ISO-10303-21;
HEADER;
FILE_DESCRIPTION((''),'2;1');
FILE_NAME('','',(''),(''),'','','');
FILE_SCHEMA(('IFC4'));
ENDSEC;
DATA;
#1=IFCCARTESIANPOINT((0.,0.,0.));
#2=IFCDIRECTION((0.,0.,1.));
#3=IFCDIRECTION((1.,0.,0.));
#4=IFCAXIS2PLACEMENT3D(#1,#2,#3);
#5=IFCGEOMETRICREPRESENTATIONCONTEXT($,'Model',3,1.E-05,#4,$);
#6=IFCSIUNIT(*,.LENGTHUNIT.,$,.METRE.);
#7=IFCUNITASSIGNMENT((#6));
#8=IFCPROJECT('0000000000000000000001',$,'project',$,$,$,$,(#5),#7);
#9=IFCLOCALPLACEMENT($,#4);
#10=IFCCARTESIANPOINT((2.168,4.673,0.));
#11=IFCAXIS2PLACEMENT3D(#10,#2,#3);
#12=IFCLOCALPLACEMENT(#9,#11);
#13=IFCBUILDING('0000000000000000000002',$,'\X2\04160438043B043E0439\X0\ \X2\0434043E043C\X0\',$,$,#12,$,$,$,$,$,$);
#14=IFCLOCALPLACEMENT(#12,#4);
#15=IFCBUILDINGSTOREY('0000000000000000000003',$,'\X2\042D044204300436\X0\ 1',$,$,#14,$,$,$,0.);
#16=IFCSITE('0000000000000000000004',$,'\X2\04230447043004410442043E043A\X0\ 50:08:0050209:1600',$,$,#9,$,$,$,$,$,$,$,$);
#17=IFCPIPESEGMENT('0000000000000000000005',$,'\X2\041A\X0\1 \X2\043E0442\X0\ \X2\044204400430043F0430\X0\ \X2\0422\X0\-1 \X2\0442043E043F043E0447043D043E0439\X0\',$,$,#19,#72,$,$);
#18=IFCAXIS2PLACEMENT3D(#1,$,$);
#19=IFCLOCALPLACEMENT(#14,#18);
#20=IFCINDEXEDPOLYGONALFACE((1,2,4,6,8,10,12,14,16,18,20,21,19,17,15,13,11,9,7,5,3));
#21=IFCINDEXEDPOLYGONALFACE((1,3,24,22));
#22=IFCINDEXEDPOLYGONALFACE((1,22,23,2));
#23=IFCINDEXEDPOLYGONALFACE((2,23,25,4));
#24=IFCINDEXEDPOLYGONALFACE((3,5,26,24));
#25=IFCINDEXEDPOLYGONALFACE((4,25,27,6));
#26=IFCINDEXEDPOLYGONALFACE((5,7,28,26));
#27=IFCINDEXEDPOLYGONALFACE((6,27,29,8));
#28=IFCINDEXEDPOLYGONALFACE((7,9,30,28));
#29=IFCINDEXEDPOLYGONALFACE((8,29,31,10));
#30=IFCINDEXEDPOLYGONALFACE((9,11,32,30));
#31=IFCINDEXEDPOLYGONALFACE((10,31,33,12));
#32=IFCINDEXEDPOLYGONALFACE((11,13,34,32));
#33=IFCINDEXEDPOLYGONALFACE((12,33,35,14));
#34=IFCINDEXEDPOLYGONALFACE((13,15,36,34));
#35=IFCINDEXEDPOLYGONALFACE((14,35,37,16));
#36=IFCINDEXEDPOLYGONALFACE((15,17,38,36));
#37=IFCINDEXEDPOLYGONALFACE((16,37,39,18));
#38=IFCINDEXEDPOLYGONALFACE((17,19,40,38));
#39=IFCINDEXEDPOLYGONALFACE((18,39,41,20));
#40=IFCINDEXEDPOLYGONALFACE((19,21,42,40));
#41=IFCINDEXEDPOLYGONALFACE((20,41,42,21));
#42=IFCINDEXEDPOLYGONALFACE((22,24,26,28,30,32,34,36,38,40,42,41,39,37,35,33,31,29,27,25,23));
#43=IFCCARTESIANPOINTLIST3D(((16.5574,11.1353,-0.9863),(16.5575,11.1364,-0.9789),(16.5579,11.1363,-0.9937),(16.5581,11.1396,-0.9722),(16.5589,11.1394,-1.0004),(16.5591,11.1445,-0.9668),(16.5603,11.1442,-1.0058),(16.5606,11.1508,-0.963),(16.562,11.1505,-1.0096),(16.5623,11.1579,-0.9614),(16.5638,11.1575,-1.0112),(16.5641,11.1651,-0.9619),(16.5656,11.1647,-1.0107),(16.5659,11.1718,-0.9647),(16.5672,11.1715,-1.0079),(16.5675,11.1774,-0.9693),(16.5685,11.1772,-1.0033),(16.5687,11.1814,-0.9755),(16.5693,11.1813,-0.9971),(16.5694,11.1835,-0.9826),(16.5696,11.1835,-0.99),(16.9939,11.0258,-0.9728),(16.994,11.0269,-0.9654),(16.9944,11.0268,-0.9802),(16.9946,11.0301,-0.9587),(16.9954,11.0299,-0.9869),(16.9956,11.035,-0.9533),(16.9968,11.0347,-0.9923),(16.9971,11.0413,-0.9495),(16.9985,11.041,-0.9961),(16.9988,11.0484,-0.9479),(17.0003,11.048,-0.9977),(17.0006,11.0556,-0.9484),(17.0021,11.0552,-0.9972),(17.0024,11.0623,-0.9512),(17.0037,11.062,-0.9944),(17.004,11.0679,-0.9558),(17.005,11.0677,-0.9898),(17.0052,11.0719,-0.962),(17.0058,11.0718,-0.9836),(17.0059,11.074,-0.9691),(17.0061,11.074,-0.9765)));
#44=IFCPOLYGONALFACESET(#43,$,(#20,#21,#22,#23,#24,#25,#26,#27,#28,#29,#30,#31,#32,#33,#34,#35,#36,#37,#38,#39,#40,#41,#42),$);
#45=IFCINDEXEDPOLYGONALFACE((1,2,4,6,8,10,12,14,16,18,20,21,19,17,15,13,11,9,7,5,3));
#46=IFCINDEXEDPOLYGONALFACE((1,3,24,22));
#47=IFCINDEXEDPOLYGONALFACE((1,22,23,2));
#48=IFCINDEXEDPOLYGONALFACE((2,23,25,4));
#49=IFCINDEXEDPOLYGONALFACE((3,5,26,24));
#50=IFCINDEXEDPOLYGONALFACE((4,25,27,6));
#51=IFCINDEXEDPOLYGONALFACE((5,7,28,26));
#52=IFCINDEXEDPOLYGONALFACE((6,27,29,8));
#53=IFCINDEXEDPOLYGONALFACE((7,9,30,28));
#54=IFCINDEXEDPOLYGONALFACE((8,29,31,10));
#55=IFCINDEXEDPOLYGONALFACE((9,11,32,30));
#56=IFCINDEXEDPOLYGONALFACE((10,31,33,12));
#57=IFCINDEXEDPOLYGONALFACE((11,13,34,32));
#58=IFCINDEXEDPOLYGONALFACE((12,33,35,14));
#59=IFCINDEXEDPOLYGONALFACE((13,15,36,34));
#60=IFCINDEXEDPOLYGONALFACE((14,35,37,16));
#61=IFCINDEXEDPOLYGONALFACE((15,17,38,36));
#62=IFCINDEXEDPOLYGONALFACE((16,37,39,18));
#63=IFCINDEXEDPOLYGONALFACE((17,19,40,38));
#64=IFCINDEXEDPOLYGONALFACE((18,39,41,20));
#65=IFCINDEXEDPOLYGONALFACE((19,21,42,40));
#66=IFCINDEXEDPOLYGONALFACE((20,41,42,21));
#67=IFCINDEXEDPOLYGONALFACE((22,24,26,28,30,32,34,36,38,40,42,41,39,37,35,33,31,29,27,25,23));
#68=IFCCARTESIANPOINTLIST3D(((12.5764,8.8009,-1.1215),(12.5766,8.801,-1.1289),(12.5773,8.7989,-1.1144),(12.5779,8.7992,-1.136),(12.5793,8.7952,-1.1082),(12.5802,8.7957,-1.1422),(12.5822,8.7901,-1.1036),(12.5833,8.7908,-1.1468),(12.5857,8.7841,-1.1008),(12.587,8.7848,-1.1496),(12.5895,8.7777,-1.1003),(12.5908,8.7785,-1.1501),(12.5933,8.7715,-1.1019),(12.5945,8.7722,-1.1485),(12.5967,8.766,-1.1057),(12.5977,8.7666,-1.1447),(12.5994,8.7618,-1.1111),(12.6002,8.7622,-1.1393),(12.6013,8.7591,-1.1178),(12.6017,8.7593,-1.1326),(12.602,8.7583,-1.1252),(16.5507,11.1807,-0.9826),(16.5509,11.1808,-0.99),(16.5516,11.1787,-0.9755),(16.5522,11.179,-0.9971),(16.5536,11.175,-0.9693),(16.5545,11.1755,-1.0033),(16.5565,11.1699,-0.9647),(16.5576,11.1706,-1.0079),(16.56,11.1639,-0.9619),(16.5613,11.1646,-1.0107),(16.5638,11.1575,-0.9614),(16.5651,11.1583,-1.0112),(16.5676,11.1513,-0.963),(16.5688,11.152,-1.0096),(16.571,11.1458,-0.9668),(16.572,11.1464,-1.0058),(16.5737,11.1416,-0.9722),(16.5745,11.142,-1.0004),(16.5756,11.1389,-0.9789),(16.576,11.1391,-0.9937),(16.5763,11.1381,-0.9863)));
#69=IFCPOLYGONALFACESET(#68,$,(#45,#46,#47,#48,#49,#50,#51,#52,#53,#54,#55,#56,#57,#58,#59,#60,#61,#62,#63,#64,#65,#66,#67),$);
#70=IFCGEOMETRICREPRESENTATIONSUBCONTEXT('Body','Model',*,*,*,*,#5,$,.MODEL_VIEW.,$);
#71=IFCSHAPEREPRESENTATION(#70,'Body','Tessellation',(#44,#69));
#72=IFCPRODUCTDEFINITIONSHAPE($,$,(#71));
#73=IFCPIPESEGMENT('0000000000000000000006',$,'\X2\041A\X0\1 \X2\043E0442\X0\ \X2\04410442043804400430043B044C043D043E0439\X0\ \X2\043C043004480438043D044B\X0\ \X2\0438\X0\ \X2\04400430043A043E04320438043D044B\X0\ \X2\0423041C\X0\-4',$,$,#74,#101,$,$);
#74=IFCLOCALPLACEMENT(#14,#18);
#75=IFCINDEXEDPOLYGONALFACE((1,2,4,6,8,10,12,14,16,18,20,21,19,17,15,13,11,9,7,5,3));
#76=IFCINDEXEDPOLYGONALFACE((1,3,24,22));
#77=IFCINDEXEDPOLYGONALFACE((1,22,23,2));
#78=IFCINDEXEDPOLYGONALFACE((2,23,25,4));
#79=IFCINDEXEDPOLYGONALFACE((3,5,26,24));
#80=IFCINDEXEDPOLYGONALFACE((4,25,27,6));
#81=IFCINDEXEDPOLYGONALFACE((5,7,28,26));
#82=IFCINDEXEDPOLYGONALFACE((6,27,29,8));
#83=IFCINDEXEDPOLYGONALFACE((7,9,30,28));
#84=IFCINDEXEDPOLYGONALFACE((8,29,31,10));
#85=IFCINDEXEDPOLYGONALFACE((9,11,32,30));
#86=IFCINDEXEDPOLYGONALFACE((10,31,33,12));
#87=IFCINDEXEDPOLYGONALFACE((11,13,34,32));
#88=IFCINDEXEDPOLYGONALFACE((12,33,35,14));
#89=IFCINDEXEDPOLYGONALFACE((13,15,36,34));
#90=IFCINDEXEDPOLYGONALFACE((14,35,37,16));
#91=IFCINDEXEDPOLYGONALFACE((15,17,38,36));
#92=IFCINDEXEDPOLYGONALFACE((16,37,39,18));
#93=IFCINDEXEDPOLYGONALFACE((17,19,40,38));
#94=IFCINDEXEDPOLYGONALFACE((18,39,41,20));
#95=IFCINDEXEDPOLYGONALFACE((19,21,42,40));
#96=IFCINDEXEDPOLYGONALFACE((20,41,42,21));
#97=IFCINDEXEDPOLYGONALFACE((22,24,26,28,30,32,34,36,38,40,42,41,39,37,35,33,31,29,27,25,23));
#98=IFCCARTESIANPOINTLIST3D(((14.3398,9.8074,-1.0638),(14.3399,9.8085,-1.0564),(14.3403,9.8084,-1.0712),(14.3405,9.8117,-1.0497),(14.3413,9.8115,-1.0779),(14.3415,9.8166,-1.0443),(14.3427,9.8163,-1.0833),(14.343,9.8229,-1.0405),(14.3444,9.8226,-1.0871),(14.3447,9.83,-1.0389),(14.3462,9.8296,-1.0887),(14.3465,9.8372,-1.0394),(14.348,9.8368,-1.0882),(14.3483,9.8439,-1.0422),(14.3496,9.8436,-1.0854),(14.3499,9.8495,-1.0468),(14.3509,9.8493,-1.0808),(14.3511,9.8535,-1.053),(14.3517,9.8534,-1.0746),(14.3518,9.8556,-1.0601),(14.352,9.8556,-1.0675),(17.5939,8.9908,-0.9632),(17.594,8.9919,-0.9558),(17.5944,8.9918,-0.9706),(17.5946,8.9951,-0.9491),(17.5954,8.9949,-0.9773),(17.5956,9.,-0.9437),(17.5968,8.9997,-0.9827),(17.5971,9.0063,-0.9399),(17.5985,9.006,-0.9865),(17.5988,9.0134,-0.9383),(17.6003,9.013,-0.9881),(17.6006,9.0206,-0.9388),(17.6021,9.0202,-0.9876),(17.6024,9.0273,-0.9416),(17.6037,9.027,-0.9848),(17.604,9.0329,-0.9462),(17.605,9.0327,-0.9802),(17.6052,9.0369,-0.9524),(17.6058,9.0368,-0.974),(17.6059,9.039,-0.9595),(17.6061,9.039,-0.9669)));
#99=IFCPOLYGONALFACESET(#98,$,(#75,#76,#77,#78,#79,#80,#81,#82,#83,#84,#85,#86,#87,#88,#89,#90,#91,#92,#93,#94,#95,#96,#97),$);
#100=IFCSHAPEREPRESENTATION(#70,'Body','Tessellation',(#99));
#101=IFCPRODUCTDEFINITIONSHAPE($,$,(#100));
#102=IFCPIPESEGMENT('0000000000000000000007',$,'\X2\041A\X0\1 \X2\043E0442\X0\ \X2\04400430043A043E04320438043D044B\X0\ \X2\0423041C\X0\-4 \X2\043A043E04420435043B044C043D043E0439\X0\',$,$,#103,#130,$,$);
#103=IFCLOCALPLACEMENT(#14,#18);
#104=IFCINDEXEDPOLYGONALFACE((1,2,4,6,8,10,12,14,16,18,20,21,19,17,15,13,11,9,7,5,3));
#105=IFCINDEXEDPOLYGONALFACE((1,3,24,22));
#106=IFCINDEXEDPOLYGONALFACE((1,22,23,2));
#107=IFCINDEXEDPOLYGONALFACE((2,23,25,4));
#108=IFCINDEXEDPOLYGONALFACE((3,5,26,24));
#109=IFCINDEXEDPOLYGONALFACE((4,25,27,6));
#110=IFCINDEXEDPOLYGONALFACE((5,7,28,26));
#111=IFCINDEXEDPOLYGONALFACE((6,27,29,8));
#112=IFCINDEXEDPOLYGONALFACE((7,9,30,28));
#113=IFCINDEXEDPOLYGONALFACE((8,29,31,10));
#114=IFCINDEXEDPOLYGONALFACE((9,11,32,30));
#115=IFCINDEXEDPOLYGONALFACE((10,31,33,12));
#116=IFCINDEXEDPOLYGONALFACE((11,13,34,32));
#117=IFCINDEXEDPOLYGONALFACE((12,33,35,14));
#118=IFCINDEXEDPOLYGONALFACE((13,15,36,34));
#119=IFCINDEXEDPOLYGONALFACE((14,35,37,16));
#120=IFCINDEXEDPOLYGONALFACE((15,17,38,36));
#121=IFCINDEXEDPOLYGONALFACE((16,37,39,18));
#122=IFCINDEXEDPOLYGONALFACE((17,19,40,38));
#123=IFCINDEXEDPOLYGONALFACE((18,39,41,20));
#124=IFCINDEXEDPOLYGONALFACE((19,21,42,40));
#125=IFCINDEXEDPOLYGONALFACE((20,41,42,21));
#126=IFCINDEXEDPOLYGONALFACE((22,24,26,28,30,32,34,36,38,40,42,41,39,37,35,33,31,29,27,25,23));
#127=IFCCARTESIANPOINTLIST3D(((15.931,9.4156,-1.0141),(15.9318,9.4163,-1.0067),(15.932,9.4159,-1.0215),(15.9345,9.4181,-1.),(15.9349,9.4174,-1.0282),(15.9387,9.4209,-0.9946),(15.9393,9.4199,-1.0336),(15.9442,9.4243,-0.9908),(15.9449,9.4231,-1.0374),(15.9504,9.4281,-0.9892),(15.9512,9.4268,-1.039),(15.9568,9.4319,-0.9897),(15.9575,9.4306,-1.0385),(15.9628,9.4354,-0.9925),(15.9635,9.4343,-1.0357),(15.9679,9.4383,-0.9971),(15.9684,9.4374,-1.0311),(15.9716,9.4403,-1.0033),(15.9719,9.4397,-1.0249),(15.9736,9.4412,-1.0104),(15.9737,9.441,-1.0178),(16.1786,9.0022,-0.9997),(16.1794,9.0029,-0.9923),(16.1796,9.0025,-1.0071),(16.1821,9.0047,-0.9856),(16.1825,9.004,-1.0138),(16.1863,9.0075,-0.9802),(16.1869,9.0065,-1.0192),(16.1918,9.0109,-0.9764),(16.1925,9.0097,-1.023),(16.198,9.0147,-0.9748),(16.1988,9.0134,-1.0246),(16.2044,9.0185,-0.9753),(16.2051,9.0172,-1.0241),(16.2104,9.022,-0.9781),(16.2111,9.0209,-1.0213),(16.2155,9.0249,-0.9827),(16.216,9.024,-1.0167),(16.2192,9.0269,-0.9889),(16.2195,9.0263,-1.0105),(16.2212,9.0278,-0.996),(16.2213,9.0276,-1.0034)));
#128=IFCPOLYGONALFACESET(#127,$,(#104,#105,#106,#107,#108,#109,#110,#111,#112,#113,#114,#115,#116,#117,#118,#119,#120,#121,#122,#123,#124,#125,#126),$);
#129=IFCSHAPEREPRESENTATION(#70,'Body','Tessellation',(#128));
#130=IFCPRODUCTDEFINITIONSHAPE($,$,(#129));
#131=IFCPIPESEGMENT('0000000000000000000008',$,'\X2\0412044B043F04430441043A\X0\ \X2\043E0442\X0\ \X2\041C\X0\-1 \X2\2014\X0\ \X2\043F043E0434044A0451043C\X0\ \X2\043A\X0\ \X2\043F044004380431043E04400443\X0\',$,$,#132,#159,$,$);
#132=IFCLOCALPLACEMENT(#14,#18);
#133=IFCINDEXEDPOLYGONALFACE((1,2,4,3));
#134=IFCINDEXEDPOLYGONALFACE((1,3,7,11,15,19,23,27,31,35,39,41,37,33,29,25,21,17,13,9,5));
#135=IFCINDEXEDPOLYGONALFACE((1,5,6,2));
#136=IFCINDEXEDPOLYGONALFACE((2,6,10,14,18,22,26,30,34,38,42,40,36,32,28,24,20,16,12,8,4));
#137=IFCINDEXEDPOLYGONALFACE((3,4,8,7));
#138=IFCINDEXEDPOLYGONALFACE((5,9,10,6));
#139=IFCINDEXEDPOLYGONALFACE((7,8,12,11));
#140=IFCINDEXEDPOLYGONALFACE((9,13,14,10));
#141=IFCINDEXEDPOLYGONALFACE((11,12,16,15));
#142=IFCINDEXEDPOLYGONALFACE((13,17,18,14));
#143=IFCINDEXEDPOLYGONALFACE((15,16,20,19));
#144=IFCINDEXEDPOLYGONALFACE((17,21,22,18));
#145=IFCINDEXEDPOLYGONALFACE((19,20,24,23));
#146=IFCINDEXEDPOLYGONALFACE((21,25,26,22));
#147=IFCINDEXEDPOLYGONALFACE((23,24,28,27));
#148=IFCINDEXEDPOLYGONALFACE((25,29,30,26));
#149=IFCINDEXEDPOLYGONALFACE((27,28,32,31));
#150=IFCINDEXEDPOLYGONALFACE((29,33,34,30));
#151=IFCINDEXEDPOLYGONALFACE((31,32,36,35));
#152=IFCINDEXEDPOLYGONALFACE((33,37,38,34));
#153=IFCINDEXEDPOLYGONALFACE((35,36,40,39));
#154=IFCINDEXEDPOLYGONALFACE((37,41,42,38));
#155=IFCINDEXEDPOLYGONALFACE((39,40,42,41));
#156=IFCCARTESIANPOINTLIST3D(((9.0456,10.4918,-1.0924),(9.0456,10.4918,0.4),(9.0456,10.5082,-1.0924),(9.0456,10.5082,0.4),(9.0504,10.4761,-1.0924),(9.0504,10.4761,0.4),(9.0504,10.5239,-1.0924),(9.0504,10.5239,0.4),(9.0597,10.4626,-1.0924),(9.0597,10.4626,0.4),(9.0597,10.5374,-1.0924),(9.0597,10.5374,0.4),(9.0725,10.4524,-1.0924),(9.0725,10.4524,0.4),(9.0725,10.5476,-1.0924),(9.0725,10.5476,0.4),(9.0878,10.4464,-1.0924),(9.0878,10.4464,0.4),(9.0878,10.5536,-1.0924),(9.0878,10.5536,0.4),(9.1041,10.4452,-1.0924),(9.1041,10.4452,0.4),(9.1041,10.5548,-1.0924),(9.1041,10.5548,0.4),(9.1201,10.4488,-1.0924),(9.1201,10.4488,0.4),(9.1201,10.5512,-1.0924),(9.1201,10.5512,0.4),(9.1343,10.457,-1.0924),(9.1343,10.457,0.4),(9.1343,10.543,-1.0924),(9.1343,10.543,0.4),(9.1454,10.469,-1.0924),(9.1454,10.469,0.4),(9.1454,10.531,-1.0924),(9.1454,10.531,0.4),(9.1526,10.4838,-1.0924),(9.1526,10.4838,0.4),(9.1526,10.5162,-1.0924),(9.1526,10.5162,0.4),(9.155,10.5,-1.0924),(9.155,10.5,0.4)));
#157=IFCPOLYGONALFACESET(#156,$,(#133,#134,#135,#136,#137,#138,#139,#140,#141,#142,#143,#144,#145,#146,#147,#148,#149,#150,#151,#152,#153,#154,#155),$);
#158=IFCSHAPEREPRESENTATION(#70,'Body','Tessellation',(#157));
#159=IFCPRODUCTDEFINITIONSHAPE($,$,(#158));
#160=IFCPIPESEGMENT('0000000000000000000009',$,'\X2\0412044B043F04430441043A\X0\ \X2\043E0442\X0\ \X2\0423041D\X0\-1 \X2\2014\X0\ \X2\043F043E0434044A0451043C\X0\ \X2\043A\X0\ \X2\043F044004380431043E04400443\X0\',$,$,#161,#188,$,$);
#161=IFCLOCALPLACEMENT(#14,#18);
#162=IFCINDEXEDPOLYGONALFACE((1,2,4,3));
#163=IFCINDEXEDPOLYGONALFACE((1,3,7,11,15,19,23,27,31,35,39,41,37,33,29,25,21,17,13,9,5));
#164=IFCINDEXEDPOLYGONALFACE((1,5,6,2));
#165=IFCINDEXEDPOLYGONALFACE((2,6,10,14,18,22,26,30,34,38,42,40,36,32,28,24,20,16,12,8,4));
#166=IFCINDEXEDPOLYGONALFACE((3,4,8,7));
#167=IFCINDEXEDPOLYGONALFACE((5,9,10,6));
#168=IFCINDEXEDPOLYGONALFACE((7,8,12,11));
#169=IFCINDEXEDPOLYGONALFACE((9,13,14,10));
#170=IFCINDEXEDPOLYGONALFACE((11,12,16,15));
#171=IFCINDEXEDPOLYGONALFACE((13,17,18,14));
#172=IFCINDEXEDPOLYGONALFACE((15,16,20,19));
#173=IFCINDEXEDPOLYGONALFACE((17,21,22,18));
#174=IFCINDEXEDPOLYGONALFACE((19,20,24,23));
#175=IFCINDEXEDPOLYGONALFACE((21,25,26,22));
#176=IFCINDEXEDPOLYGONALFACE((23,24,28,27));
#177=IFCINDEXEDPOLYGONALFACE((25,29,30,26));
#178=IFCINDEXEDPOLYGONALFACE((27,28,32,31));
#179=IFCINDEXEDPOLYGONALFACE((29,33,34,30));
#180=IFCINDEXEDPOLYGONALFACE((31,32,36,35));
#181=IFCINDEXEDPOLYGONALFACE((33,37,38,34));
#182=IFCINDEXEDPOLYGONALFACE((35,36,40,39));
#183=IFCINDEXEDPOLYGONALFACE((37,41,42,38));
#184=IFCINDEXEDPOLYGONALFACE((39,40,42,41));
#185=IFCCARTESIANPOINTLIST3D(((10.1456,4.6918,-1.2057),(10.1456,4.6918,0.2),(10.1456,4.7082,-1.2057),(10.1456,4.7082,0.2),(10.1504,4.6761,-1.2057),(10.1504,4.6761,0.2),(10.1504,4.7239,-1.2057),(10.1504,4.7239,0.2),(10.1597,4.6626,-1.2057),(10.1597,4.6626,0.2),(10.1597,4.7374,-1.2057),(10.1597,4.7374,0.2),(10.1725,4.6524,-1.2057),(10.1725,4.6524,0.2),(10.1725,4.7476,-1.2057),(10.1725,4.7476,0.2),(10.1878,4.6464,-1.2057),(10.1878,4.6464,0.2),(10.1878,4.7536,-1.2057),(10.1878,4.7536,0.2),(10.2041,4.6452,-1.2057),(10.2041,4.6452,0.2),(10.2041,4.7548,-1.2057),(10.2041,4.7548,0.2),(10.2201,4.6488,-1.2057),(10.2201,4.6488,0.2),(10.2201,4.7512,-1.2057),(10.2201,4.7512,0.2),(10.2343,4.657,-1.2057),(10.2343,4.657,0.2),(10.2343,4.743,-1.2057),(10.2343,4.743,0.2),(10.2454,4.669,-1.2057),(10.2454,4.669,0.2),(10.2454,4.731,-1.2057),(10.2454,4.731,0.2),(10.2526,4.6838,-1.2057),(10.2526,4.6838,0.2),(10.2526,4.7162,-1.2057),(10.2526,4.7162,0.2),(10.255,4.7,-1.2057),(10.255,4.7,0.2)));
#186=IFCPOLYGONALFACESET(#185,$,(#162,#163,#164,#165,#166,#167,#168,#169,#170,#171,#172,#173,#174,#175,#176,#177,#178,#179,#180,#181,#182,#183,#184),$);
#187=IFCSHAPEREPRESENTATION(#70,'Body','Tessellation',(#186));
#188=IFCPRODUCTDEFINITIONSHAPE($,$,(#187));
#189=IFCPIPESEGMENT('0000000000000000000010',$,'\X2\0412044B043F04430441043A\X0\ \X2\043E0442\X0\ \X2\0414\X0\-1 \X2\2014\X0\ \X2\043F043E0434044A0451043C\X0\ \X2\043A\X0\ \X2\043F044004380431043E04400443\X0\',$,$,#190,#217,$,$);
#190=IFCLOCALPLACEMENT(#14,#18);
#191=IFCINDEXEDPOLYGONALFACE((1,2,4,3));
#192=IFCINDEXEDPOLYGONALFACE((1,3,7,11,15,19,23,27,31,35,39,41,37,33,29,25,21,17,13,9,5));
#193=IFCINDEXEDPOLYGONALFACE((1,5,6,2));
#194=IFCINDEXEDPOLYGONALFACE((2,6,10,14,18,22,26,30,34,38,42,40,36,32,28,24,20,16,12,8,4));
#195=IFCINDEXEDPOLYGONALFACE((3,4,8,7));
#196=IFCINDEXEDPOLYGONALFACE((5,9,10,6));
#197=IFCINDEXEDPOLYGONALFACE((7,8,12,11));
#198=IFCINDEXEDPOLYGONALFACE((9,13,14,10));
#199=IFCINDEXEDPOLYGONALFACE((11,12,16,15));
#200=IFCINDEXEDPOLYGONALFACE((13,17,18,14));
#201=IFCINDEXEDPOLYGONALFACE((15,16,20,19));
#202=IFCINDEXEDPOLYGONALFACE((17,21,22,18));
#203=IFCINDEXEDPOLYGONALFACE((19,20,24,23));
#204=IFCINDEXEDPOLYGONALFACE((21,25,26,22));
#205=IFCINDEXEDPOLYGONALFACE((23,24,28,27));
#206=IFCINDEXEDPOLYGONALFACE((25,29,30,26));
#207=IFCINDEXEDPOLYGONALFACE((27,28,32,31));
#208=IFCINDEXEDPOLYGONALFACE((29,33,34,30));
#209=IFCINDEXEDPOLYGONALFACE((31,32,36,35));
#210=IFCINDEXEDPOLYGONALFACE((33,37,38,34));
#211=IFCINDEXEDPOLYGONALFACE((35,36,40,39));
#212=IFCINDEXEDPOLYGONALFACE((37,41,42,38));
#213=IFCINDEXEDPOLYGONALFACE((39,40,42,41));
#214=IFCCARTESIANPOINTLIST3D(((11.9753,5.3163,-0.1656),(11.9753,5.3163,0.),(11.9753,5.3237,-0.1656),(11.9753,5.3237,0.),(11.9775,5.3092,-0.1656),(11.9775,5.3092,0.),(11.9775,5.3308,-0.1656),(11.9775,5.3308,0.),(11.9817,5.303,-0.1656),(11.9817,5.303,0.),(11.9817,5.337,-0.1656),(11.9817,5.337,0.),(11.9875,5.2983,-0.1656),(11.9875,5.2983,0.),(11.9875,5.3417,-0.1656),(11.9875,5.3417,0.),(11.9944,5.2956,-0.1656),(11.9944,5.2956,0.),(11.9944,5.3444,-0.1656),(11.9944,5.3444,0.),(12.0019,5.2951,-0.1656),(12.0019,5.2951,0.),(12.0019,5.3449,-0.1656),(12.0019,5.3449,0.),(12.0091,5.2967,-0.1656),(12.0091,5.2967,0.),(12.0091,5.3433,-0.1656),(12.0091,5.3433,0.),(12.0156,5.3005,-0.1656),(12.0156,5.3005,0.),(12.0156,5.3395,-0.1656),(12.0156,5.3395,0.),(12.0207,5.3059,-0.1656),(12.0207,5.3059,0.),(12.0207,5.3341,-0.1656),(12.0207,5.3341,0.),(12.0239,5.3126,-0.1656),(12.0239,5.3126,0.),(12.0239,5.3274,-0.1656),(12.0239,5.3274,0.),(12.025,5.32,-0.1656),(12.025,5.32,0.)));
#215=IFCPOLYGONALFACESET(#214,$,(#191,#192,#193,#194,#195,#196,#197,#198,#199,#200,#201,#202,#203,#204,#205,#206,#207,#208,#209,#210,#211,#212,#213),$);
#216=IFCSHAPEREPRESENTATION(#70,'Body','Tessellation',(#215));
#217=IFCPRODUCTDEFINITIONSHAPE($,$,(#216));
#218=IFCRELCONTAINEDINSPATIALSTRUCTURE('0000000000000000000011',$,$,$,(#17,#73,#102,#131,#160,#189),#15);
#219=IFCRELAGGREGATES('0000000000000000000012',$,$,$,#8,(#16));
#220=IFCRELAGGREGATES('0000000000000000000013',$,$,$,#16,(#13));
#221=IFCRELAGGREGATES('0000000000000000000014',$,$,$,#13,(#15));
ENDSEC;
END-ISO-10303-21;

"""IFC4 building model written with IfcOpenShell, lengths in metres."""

from ifc_helpers import new_model, si_unit, frame, origin_with_axes, origin_2d, place, context, subcontext, project, spatial, circle, extrude, element, save


model = new_model("IFC4")

# Units and contexts
model_context = context("Model", 3, precision=1e-05, world=origin_with_axes())
body_context = subcontext(model_context, "Body", "Model", "MODEL_VIEW")
ifc_project = project(units=[si_unit("LENGTHUNIT", "METRE")], contexts=[model_context])

# Site, building, storey
site_placement = place(None, origin_with_axes())
site = spatial("IfcSite", under=ifc_project, at=site_placement, Name="Участок 50:08:0050209:1600")
building_placement = place(site_placement, frame((2.168, 4.673, 0.0), z_axis=(0.0, 0.0, 1.0), x_axis=(1.0, 0.0, 0.0)))
building = spatial("IfcBuilding", under=site, at=building_placement, Name="Жилой дом")
storey_placement = place(building_placement, origin_with_axes())
storey = spatial("IfcBuildingStorey", under=building, at=storey_placement, Name="Этаж 1", Elevation=0.0)

# Pipe segments
pipe_segment_1_placement = place(storey_placement, origin_with_axes())
element("IfcPipeSegment", 1, at=pipe_segment_1_placement, inside=storey, Name="К1 от трапа Т-1 топочной", context=body_context, shape_type="SweptSolid", body=[
    extrude(circle(Radius=0.025, at=origin_2d()), frame((17.0, 11.05, -0.9728), z_axis=(-0.96951, 0.24321, -0.029985), x_axis=(-0.24332, -0.969946, 0.0)), (0.0, 0.0, 1.0), 0.4502),
    extrude(circle(Radius=0.025, at=origin_2d()), frame((16.5635, 11.1595, -0.9863), z_axis=(-0.857562, -0.513506, -0.029971), x_axis=(0.513737, -0.857948, 0.0)), (0.0, 0.0, 1.0), 4.6344),
])
pipe_segment_2_placement = place(storey_placement, origin_with_axes())
element("IfcPipeSegment", 2, at=pipe_segment_2_placement, inside=storey, Name="К1 от стиральной машины и раковины УМ-4", context=body_context, shape_type="SweptSolid", body=[
    extrude(circle(Radius=0.025, at=origin_2d()), frame((17.6, 9.015, -0.9632), z_axis=(-0.969491, 0.243289, -0.029972), x_axis=(-0.243398, -0.969926, 0.0)), (0.0, 0.0, 1.0), 3.3565),
])
pipe_segment_3_placement = place(storey_placement, origin_with_axes())
element("IfcPipeSegment", 3, at=pipe_segment_3_placement, inside=storey, Name="К1 от раковины УМ-4 котельной", context=body_context, shape_type="SweptSolid", body=[
    extrude(circle(Radius=0.025, at=origin_2d()), frame((16.2, 9.015, -0.9997), z_axis=(-0.513595, 0.857513, -0.02987), x_axis=(-0.857895, -0.513824, 0.0)), (0.0, 0.0, 1.0), 0.4821),
])
pipe_segment_4_placement = place(storey_placement, origin_with_axes())
element("IfcPipeSegment", 4, at=pipe_segment_4_placement, inside=storey, Name="Выпуск от М-1 — подъём к прибору", context=body_context, shape_type="SweptSolid", body=[
    extrude(circle(Radius=0.055, at=origin_2d()), frame((9.1, 10.5, 0.4), z_axis=(0.0, 0.0, -1.0), x_axis=(1.0, 0.0, 0.0)), (0.0, 0.0, 1.0), 1.4924),
])
pipe_segment_5_placement = place(storey_placement, origin_with_axes())
element("IfcPipeSegment", 5, at=pipe_segment_5_placement, inside=storey, Name="Выпуск от УН-1 — подъём к прибору", context=body_context, shape_type="SweptSolid", body=[
    extrude(circle(Radius=0.055, at=origin_2d()), frame((10.2, 4.7, 0.2), z_axis=(0.0, 0.0, -1.0), x_axis=(1.0, 0.0, 0.0)), (0.0, 0.0, 1.0), 1.4057),
])
pipe_segment_6_placement = place(storey_placement, origin_with_axes())
element("IfcPipeSegment", 6, at=pipe_segment_6_placement, inside=storey, Name="Выпуск от Д-1 — подъём к прибору", context=body_context, shape_type="SweptSolid", body=[
    extrude(circle(Radius=0.025, at=origin_2d()), frame((12.0, 5.32, 0.0), z_axis=(0.0, 0.0, -1.0), x_axis=(1.0, 0.0, 0.0)), (0.0, 0.0, 1.0), 0.1656),
])

save(model, "model.ifc")
